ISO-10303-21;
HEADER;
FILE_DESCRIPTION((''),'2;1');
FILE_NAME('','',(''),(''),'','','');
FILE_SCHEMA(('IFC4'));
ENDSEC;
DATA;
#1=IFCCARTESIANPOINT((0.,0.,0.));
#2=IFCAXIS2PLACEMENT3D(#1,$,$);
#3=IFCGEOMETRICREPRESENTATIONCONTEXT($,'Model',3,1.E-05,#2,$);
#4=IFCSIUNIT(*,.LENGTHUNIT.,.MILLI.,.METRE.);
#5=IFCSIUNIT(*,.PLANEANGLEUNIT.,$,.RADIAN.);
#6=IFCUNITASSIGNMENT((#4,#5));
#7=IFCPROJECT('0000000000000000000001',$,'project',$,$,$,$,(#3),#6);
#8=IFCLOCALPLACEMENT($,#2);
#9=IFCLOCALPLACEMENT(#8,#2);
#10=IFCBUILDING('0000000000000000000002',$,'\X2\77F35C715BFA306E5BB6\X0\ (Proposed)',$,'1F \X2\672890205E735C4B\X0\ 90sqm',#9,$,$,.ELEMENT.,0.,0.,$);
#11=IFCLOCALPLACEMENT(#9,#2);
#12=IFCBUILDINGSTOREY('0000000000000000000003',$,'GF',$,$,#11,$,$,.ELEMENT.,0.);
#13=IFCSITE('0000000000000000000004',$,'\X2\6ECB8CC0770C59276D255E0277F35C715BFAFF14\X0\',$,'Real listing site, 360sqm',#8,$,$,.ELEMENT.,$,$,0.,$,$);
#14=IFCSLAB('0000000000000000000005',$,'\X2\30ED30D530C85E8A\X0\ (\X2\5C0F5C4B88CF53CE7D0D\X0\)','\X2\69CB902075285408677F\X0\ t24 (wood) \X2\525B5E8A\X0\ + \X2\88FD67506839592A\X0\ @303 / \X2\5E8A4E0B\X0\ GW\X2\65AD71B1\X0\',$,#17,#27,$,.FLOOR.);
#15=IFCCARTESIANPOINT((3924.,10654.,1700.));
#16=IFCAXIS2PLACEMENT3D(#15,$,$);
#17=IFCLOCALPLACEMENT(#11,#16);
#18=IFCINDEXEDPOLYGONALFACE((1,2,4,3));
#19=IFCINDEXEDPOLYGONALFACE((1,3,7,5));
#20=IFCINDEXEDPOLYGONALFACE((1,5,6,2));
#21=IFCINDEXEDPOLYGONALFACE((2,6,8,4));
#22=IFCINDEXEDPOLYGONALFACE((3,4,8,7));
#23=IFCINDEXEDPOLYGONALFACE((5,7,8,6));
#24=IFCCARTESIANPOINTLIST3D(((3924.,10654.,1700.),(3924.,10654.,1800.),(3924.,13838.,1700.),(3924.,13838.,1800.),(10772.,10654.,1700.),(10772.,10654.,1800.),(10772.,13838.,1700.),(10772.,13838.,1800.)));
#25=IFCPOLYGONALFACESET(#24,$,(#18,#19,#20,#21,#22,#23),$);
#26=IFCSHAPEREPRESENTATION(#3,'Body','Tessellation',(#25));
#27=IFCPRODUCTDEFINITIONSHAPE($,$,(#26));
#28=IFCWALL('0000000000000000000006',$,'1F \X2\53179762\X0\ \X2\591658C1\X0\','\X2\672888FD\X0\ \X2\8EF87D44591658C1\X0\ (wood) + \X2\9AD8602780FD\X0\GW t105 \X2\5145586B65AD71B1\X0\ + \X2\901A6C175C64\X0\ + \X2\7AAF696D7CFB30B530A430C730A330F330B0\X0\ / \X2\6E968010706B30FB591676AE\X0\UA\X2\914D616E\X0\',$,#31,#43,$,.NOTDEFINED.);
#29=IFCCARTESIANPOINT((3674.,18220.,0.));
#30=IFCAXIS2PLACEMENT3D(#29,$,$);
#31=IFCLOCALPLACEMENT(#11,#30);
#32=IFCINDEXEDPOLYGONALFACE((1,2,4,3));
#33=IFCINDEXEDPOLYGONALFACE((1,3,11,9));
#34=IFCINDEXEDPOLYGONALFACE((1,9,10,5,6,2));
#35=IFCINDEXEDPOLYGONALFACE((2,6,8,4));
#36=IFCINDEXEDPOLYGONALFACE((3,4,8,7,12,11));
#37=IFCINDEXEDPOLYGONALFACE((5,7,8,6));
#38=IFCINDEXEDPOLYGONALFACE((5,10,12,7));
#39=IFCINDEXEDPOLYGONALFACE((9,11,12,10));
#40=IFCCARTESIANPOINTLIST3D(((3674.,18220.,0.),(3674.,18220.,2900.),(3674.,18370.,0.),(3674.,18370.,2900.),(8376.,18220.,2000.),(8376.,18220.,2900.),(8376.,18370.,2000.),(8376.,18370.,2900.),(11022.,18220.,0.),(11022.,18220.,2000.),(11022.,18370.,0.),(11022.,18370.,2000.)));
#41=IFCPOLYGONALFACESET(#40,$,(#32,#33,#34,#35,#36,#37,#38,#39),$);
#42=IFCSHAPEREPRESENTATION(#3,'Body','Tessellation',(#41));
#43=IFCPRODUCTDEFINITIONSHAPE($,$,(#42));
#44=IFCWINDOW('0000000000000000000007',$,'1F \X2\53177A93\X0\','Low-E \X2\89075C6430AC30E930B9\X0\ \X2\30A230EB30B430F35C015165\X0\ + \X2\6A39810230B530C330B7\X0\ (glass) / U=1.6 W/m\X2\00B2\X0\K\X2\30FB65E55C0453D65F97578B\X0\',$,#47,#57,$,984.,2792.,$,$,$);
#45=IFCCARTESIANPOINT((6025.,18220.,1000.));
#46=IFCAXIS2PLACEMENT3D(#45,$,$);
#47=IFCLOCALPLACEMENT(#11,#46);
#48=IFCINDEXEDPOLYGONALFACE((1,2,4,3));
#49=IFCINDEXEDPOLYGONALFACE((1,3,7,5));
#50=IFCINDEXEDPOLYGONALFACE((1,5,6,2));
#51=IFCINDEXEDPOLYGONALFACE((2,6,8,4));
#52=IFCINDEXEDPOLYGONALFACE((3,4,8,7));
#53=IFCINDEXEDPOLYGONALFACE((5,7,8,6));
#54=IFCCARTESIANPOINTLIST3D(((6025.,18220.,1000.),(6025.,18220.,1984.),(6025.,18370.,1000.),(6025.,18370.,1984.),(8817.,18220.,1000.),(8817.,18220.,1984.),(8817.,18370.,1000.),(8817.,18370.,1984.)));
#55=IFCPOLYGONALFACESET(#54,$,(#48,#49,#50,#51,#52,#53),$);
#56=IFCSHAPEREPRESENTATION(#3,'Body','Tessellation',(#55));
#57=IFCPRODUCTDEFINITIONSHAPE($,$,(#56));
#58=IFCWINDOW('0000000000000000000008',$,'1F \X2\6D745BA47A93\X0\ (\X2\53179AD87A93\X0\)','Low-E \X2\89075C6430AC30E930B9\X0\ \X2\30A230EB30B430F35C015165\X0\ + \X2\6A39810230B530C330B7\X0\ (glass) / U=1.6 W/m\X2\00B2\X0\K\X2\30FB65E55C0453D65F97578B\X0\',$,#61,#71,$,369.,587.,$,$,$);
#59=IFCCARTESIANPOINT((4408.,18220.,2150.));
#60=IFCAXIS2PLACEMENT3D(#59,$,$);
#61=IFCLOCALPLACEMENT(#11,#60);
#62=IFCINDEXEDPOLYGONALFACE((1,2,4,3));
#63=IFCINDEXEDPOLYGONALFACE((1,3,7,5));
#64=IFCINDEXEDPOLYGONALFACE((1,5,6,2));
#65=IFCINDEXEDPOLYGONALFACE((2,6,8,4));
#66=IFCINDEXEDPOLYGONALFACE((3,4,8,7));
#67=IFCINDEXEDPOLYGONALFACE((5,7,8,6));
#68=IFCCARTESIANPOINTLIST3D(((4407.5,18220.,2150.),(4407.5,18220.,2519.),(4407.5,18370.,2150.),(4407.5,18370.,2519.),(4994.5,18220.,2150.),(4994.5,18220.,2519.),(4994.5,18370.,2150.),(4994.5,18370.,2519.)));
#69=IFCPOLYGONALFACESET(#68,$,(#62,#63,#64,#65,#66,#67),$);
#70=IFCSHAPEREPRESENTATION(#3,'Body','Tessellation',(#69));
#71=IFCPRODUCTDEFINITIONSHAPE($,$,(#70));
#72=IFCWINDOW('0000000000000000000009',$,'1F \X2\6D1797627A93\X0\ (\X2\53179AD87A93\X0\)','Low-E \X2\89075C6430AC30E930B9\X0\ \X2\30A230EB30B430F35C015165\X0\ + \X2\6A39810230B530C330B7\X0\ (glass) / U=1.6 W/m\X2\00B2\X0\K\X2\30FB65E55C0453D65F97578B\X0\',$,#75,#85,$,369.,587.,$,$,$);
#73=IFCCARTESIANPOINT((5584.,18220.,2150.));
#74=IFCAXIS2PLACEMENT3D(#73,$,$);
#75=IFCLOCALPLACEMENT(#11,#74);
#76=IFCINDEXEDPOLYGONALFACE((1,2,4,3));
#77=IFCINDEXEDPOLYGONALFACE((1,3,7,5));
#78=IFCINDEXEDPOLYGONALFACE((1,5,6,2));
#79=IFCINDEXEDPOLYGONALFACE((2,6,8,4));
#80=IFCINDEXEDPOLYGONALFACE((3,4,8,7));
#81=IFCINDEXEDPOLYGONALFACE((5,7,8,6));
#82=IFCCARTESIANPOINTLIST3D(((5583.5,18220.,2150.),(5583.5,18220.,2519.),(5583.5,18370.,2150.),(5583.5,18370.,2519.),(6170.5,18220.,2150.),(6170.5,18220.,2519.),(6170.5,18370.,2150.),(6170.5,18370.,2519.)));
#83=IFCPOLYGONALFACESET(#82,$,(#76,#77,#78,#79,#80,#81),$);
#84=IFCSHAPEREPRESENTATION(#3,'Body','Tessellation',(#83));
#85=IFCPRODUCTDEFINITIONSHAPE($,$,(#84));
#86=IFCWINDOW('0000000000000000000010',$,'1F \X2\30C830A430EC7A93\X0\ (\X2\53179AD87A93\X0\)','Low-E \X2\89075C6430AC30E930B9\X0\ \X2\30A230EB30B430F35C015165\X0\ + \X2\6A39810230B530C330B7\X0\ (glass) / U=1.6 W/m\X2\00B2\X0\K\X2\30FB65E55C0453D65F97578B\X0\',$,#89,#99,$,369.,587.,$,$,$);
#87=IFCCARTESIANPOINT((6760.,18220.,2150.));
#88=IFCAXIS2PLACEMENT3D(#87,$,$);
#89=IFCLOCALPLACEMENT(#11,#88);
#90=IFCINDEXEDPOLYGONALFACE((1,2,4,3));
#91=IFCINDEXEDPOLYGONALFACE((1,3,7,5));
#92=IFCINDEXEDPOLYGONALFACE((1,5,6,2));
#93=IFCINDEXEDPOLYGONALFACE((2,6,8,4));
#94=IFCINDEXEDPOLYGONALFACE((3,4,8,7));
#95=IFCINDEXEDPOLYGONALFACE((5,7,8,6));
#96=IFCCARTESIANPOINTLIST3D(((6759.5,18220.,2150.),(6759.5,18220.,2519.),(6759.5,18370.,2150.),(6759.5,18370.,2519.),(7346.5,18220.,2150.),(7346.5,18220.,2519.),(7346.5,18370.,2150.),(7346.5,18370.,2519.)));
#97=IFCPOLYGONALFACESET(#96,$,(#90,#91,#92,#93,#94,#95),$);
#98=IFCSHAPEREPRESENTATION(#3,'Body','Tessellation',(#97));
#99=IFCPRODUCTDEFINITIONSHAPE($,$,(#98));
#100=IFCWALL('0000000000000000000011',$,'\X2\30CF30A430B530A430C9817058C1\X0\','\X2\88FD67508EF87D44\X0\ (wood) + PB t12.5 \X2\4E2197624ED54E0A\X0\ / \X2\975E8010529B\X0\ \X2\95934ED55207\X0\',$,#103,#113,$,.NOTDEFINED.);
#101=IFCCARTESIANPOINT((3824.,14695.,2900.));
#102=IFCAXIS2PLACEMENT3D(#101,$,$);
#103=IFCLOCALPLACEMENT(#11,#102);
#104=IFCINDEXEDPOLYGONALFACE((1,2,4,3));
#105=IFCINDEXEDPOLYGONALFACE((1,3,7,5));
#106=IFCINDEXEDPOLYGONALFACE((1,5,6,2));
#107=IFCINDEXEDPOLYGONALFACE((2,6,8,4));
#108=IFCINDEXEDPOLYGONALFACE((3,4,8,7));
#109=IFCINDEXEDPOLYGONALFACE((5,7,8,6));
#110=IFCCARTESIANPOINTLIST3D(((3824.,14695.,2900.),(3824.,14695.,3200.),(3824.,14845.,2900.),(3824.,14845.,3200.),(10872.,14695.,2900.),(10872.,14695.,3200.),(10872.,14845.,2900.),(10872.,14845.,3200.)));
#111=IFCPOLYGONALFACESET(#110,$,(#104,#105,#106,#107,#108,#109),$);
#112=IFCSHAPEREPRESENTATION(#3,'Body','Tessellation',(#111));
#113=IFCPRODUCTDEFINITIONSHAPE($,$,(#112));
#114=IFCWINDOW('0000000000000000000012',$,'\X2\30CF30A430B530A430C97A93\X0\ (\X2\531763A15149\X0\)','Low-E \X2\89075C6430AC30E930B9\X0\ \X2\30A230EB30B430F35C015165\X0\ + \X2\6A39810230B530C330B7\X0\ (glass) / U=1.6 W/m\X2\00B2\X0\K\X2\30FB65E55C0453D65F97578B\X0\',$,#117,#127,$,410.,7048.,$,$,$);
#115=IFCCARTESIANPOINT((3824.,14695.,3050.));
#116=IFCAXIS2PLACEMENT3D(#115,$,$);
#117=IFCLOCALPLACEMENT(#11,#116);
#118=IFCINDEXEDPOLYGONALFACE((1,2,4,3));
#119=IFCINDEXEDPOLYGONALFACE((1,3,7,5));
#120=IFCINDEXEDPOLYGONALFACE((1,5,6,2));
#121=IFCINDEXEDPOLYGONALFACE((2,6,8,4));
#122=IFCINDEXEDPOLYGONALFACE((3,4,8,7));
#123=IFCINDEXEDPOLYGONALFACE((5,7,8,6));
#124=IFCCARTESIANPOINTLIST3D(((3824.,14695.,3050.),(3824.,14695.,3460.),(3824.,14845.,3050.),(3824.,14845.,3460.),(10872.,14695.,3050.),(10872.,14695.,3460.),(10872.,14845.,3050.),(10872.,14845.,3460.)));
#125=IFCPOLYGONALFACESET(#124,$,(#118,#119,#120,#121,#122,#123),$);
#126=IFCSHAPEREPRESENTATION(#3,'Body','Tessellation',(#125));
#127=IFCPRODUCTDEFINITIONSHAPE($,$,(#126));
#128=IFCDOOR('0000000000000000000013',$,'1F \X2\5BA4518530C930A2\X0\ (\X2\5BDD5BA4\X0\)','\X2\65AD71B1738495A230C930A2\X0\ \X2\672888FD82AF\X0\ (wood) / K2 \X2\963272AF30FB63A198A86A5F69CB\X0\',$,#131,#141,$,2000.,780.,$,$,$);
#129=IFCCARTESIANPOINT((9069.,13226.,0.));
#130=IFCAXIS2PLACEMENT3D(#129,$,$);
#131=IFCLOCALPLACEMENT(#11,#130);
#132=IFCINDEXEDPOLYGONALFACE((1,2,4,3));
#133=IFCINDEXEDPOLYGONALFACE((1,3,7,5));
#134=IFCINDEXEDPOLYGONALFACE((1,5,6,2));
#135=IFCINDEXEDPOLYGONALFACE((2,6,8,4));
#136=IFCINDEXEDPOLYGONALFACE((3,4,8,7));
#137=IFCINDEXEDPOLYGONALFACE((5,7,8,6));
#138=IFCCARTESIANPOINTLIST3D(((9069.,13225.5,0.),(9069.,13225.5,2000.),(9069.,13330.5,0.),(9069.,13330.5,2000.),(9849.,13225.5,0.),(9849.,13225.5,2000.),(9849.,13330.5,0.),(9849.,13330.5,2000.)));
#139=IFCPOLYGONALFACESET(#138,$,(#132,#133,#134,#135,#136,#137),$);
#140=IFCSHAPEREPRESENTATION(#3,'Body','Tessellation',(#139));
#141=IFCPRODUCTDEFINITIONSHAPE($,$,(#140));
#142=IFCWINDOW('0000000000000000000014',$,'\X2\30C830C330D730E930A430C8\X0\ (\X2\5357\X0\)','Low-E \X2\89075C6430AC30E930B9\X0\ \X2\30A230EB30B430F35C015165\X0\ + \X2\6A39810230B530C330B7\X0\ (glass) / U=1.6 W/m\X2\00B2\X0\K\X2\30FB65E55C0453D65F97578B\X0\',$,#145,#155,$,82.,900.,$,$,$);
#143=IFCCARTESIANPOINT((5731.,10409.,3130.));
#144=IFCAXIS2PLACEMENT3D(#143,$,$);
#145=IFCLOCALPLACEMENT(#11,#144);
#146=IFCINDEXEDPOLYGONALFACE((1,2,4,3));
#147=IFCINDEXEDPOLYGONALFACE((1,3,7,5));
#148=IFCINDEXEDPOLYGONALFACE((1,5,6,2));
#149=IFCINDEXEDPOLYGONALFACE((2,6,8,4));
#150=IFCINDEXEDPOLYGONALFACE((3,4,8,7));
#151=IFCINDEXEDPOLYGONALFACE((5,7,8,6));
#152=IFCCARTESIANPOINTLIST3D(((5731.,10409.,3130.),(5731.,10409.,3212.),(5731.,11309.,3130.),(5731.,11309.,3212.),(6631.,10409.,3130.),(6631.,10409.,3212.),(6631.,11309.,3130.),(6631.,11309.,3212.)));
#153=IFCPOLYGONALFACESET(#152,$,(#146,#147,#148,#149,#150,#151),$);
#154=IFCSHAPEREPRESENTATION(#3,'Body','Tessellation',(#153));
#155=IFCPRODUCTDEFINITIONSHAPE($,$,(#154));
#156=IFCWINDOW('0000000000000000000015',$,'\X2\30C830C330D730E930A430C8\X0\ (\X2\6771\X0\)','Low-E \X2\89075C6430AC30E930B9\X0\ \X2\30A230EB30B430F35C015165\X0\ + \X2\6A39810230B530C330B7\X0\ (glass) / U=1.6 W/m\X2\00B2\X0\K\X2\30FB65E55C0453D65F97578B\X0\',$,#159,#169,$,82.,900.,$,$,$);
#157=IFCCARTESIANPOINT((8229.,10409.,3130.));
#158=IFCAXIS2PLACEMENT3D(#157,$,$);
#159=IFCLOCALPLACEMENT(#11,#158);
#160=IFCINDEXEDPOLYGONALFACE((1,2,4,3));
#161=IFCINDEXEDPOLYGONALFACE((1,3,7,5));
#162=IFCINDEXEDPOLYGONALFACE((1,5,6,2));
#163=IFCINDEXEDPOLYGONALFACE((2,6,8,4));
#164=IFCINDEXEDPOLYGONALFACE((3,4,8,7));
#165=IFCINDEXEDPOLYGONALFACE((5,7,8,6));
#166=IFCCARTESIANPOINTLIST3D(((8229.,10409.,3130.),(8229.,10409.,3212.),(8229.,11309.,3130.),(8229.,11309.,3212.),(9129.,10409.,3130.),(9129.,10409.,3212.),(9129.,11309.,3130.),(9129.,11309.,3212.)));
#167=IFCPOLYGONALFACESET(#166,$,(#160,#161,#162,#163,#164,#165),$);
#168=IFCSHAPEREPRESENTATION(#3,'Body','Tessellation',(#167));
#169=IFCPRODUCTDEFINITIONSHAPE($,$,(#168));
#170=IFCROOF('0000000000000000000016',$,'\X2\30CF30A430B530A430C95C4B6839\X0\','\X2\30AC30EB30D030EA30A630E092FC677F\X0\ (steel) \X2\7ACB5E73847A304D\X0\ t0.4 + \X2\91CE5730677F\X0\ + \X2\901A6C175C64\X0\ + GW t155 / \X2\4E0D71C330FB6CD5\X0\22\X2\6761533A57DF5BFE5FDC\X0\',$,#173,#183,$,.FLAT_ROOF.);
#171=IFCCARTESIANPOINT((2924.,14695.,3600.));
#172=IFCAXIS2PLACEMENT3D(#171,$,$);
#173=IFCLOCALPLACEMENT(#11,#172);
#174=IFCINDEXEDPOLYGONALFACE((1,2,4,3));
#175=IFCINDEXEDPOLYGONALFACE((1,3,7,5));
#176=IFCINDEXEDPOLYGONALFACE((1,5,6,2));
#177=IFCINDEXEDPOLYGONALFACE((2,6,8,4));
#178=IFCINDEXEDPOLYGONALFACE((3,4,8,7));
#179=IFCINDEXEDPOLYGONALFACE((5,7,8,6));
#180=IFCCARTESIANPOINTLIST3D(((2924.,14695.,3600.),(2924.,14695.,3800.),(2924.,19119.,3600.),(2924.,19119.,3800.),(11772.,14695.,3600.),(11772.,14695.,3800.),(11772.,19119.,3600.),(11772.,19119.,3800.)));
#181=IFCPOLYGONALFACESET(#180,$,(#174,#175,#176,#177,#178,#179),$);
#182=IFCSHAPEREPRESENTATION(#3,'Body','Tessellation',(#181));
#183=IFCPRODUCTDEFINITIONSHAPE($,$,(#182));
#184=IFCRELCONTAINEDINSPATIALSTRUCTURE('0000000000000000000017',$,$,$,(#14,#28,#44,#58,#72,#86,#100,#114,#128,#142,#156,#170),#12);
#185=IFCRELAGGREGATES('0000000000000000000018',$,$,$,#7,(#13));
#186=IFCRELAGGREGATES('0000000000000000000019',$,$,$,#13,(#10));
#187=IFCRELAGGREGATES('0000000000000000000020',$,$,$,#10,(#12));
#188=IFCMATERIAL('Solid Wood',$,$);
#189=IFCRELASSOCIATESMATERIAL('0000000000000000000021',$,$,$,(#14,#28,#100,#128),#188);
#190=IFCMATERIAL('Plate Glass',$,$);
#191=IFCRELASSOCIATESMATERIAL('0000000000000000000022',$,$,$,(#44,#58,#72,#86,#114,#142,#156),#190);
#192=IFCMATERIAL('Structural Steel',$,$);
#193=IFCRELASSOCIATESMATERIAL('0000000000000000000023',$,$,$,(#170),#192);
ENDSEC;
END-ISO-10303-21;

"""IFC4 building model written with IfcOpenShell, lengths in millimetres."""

from ifc_helpers import new_model, si_unit, frame, frame_2d, origin, place, context, project, spatial, rectangle, extrude, material, element, fill, save


model = new_model("IFC4")

# Units and contexts
model_context = context("Model", 3, precision=1e-05, world=origin())
ifc_project = project(units=[si_unit("LENGTHUNIT", "METRE", prefix="MILLI"), si_unit("PLANEANGLEUNIT", "RADIAN")], contexts=[model_context])

# Site, building, storey
site_placement = place(None, origin())
site = spatial("IfcSite", under=ifc_project, at=site_placement, Name="滋賀県大津市石山寺４", ObjectType="Real listing site, 360sqm", CompositionType="ELEMENT", RefElevation=0.0)
building_placement = place(site_placement, origin())
building = spatial("IfcBuilding", under=site, at=building_placement, Name="石山寺の家 (Proposed)", ObjectType="1F 木造平屋 90sqm", CompositionType="ELEMENT", ElevationOfRefHeight=0.0, ElevationOfTerrain=0.0)
storey_placement = place(building_placement, origin())
storey = spatial("IfcBuildingStorey", under=building, at=storey_placement, Name="GF", CompositionType="ELEMENT", Elevation=0.0)

# Slab
ifc_material_1 = material(Name="Solid Wood")
slab_placement = place(storey_placement, frame((3924.0, 10654.0, 1700.0)))
element("IfcSlab", 1, at=slab_placement, inside=storey, material=ifc_material_1, Name="ロフト床 (小屋裏収納)", Description="構造用合板 t24 (wood) 剛床 + 製材根太 @303 / 床下 GW断熱", PredefinedType="FLOOR", context=model_context, shape_type="SweptSolid", body=[
    extrude(rectangle(XDim=6848.0, YDim=3184.0, at=frame_2d((3424.0, 1592.0))), frame((3924.0, 10654.0, 1700.0)), (0.0, 0.0, 1.0), 100.0),
])

# Wall, openings, windows
wall_1_placement = place(storey_placement, frame((3674.0, 18220.0, 0.0)))
wall_1 = element("IfcWall", 2, at=wall_1_placement, inside=storey, material=ifc_material_1, Name="1F 北面 外壁", Description="木製 軸組外壁 (wood) + 高性能GW t105 充填断熱 + 通気層 + 窯業系サイディング / 準耐火・外皮UA配慮", PredefinedType="NOTDEFINED", context=model_context, shape_type="SweptSolid", body=[
    extrude(rectangle(XDim=7348.0, YDim=150.0, at=frame_2d((3674.0, 75.0))), frame((3674.0, 18220.0, 0.0)), (0.0, 0.0, 1.0), 2900.0),
])
opening_1_placement = place(storey_placement, frame((6025.0, 18220.0, 1000.0)))
opening_1 = element("IfcOpeningElement", 3, at=opening_1_placement, cuts=wall_1, PredefinedType="NOTDEFINED", context=model_context, shape_type="SweptSolid", body=[
    extrude(rectangle(XDim=2792.0, YDim=150.0, at=frame_2d((1396.0, 75.0))), frame((6025.0, 18220.0, 1000.0)), (0.0, 0.0, 1.0), 984.0),
])
opening_2_placement = place(storey_placement, frame((4408.0, 18220.0, 2150.0)))
opening_2 = element("IfcOpeningElement", 4, at=opening_2_placement, cuts=wall_1, PredefinedType="NOTDEFINED", context=model_context, shape_type="SweptSolid", body=[
    extrude(rectangle(XDim=587.0, YDim=150.0, at=frame_2d((293.0, 75.0))), frame((4408.0, 18220.0, 2150.0)), (0.0, 0.0, 1.0), 369.0),
])
opening_3_placement = place(storey_placement, frame((5584.0, 18220.0, 2150.0)))
opening_3 = element("IfcOpeningElement", 5, at=opening_3_placement, cuts=wall_1, PredefinedType="NOTDEFINED", context=model_context, shape_type="SweptSolid", body=[
    extrude(rectangle(XDim=587.0, YDim=150.0, at=frame_2d((293.0, 75.0))), frame((5584.0, 18220.0, 2150.0)), (0.0, 0.0, 1.0), 369.0),
])
opening_4_placement = place(storey_placement, frame((6760.0, 18220.0, 2150.0)))
opening_4 = element("IfcOpeningElement", 6, at=opening_4_placement, cuts=wall_1, PredefinedType="NOTDEFINED", context=model_context, shape_type="SweptSolid", body=[
    extrude(rectangle(XDim=587.0, YDim=150.0, at=frame_2d((293.0, 75.0))), frame((6760.0, 18220.0, 2150.0)), (0.0, 0.0, 1.0), 369.0),
])
ifc_material_2 = material(Name="Plate Glass")
window_1_placement = place(storey_placement, frame((6025.0, 18220.0, 1000.0)))
window_1 = element("IfcWindow", 7, at=window_1_placement, inside=storey, material=ifc_material_2, Name="1F 北窓", Description="Low-E 複層ガラス アルゴン封入 + 樹脂サッシ (glass) / U=1.6 W/m²K・日射取得型", OverallHeight=984.0, OverallWidth=2792.0, context=model_context, shape_type="SweptSolid", body=[
    extrude(rectangle(XDim=2792.0, YDim=150.0, at=frame_2d((1396.0, 75.0))), frame((6025.0, 18220.0, 1000.0)), (0.0, 0.0, 1.0), 984.0),
])
fill(opening_1, window_1)
window_2_placement = place(storey_placement, frame((4408.0, 18220.0, 2150.0)))
window_2 = element("IfcWindow", 8, at=window_2_placement, inside=storey, material=ifc_material_2, Name="1F 浴室窓 (北高窓)", Description="Low-E 複層ガラス アルゴン封入 + 樹脂サッシ (glass) / U=1.6 W/m²K・日射取得型", OverallHeight=369.0, OverallWidth=587.0, context=model_context, shape_type="SweptSolid", body=[
    extrude(rectangle(XDim=587.0, YDim=150.0, at=frame_2d((293.0, 75.0))), frame((4408.0, 18220.0, 2150.0)), (0.0, 0.0, 1.0), 369.0),
])
fill(opening_2, window_2)
window_3_placement = place(storey_placement, frame((5584.0, 18220.0, 2150.0)))
window_3 = element("IfcWindow", 9, at=window_3_placement, inside=storey, material=ifc_material_2, Name="1F 洗面窓 (北高窓)", Description="Low-E 複層ガラス アルゴン封入 + 樹脂サッシ (glass) / U=1.6 W/m²K・日射取得型", OverallHeight=369.0, OverallWidth=587.0, context=model_context, shape_type="SweptSolid", body=[
    extrude(rectangle(XDim=587.0, YDim=150.0, at=frame_2d((293.0, 75.0))), frame((5584.0, 18220.0, 2150.0)), (0.0, 0.0, 1.0), 369.0),
])
fill(opening_3, window_3)
window_4_placement = place(storey_placement, frame((6760.0, 18220.0, 2150.0)))
window_4 = element("IfcWindow", 10, at=window_4_placement, inside=storey, material=ifc_material_2, Name="1F トイレ窓 (北高窓)", Description="Low-E 複層ガラス アルゴン封入 + 樹脂サッシ (glass) / U=1.6 W/m²K・日射取得型", OverallHeight=369.0, OverallWidth=587.0, context=model_context, shape_type="SweptSolid", body=[
    extrude(rectangle(XDim=587.0, YDim=150.0, at=frame_2d((293.0, 75.0))), frame((6760.0, 18220.0, 2150.0)), (0.0, 0.0, 1.0), 369.0),
])
fill(opening_4, window_4)

# Wall, opening, window
wall_2_placement = place(storey_placement, frame((3824.0, 14695.0, 2900.0)))
wall_2 = element("IfcWall", 11, at=wall_2_placement, inside=storey, material=ifc_material_1, Name="ハイサイド腰壁", Description="製材軸組 (wood) + PB t12.5 両面仕上 / 非耐力 間仕切", PredefinedType="NOTDEFINED", context=model_context, shape_type="SweptSolid", body=[
    extrude(rectangle(XDim=7048.0, YDim=150.0, at=frame_2d((3524.0, 75.0))), frame((3824.0, 14695.0, 2900.0)), (0.0, 0.0, 1.0), 700.0),
])
opening_5_placement = place(storey_placement, frame((3824.0, 14695.0, 3050.0)))
opening_5 = element("IfcOpeningElement", 12, at=opening_5_placement, cuts=wall_2, PredefinedType="NOTDEFINED", context=model_context, shape_type="SweptSolid", body=[
    extrude(rectangle(XDim=7048.0, YDim=150.0, at=frame_2d((3524.0, 75.0))), frame((3824.0, 14695.0, 3050.0)), (0.0, 0.0, 1.0), 410.0),
])
window_5_placement = place(storey_placement, frame((3824.0, 14695.0, 3050.0)))
window_5 = element("IfcWindow", 13, at=window_5_placement, inside=storey, material=ifc_material_2, Name="ハイサイド窓 (北採光)", Description="Low-E 複層ガラス アルゴン封入 + 樹脂サッシ (glass) / U=1.6 W/m²K・日射取得型", OverallHeight=410.0, OverallWidth=7048.0, context=model_context, shape_type="SweptSolid", body=[
    extrude(rectangle(XDim=7048.0, YDim=150.0, at=frame_2d((3524.0, 75.0))), frame((3824.0, 14695.0, 3050.0)), (0.0, 0.0, 1.0), 410.0),
])
fill(opening_5, window_5)

# Door
door_1_placement = place(storey_placement, frame((9069.0, 13226.0, 0.0)))
element("IfcDoor", 14, at=door_1_placement, inside=storey, material=ifc_material_1, Name="1F 室内ドア (寝室)", Description="断熱玄関ドア 木製芯 (wood) / K2 防犯・採風機構", OverallHeight=2000.0, OverallWidth=780.0, context=model_context, shape_type="SweptSolid", body=[
    extrude(rectangle(XDim=780.0, YDim=105.0, at=frame_2d((390.0, 52.0))), frame((9069.0, 13226.0, 0.0)), (0.0, 0.0, 1.0), 2000.0),
])

# Windows
window_6_placement = place(storey_placement, frame((5731.0, 10409.0, 3130.0)))
element("IfcWindow", 15, at=window_6_placement, inside=storey, material=ifc_material_2, Name="トップライト (南)", Description="Low-E 複層ガラス アルゴン封入 + 樹脂サッシ (glass) / U=1.6 W/m²K・日射取得型", OverallHeight=82.0, OverallWidth=900.0, context=model_context, shape_type="SweptSolid", body=[
    extrude(rectangle(XDim=900.0, YDim=900.0, at=frame_2d((450.0, 450.0))), frame((5731.0, 10409.0, 3130.0)), (0.0, 0.0, 1.0), 82.0),
])
window_7_placement = place(storey_placement, frame((8229.0, 10409.0, 3130.0)))
element("IfcWindow", 16, at=window_7_placement, inside=storey, material=ifc_material_2, Name="トップライト (東)", Description="Low-E 複層ガラス アルゴン封入 + 樹脂サッシ (glass) / U=1.6 W/m²K・日射取得型", OverallHeight=82.0, OverallWidth=900.0, context=model_context, shape_type="SweptSolid", body=[
    extrude(rectangle(XDim=900.0, YDim=900.0, at=frame_2d((450.0, 450.0))), frame((8229.0, 10409.0, 3130.0)), (0.0, 0.0, 1.0), 82.0),
])

# Roof
ifc_material_3 = material(Name="Structural Steel")
roof_placement = place(storey_placement, frame((2924.0, 14695.0, 3600.0)))
element("IfcRoof", 17, at=roof_placement, inside=storey, material=ifc_material_3, Name="ハイサイド屋根", Description="ガルバリウム鋼板 (steel) 立平葺き t0.4 + 野地板 + 通気層 + GW t155 / 不燃・法22条区域対応", PredefinedType="FLAT_ROOF", context=model_context, shape_type="SweptSolid", body=[
    extrude(rectangle(XDim=8848.0, YDim=4424.0, at=frame_2d((4424.0, 2212.0))), frame((2924.0, 14695.0, 3600.0)), (0.0, 0.0, 1.0), 200.0),
])

save(model, "model.ifc")
